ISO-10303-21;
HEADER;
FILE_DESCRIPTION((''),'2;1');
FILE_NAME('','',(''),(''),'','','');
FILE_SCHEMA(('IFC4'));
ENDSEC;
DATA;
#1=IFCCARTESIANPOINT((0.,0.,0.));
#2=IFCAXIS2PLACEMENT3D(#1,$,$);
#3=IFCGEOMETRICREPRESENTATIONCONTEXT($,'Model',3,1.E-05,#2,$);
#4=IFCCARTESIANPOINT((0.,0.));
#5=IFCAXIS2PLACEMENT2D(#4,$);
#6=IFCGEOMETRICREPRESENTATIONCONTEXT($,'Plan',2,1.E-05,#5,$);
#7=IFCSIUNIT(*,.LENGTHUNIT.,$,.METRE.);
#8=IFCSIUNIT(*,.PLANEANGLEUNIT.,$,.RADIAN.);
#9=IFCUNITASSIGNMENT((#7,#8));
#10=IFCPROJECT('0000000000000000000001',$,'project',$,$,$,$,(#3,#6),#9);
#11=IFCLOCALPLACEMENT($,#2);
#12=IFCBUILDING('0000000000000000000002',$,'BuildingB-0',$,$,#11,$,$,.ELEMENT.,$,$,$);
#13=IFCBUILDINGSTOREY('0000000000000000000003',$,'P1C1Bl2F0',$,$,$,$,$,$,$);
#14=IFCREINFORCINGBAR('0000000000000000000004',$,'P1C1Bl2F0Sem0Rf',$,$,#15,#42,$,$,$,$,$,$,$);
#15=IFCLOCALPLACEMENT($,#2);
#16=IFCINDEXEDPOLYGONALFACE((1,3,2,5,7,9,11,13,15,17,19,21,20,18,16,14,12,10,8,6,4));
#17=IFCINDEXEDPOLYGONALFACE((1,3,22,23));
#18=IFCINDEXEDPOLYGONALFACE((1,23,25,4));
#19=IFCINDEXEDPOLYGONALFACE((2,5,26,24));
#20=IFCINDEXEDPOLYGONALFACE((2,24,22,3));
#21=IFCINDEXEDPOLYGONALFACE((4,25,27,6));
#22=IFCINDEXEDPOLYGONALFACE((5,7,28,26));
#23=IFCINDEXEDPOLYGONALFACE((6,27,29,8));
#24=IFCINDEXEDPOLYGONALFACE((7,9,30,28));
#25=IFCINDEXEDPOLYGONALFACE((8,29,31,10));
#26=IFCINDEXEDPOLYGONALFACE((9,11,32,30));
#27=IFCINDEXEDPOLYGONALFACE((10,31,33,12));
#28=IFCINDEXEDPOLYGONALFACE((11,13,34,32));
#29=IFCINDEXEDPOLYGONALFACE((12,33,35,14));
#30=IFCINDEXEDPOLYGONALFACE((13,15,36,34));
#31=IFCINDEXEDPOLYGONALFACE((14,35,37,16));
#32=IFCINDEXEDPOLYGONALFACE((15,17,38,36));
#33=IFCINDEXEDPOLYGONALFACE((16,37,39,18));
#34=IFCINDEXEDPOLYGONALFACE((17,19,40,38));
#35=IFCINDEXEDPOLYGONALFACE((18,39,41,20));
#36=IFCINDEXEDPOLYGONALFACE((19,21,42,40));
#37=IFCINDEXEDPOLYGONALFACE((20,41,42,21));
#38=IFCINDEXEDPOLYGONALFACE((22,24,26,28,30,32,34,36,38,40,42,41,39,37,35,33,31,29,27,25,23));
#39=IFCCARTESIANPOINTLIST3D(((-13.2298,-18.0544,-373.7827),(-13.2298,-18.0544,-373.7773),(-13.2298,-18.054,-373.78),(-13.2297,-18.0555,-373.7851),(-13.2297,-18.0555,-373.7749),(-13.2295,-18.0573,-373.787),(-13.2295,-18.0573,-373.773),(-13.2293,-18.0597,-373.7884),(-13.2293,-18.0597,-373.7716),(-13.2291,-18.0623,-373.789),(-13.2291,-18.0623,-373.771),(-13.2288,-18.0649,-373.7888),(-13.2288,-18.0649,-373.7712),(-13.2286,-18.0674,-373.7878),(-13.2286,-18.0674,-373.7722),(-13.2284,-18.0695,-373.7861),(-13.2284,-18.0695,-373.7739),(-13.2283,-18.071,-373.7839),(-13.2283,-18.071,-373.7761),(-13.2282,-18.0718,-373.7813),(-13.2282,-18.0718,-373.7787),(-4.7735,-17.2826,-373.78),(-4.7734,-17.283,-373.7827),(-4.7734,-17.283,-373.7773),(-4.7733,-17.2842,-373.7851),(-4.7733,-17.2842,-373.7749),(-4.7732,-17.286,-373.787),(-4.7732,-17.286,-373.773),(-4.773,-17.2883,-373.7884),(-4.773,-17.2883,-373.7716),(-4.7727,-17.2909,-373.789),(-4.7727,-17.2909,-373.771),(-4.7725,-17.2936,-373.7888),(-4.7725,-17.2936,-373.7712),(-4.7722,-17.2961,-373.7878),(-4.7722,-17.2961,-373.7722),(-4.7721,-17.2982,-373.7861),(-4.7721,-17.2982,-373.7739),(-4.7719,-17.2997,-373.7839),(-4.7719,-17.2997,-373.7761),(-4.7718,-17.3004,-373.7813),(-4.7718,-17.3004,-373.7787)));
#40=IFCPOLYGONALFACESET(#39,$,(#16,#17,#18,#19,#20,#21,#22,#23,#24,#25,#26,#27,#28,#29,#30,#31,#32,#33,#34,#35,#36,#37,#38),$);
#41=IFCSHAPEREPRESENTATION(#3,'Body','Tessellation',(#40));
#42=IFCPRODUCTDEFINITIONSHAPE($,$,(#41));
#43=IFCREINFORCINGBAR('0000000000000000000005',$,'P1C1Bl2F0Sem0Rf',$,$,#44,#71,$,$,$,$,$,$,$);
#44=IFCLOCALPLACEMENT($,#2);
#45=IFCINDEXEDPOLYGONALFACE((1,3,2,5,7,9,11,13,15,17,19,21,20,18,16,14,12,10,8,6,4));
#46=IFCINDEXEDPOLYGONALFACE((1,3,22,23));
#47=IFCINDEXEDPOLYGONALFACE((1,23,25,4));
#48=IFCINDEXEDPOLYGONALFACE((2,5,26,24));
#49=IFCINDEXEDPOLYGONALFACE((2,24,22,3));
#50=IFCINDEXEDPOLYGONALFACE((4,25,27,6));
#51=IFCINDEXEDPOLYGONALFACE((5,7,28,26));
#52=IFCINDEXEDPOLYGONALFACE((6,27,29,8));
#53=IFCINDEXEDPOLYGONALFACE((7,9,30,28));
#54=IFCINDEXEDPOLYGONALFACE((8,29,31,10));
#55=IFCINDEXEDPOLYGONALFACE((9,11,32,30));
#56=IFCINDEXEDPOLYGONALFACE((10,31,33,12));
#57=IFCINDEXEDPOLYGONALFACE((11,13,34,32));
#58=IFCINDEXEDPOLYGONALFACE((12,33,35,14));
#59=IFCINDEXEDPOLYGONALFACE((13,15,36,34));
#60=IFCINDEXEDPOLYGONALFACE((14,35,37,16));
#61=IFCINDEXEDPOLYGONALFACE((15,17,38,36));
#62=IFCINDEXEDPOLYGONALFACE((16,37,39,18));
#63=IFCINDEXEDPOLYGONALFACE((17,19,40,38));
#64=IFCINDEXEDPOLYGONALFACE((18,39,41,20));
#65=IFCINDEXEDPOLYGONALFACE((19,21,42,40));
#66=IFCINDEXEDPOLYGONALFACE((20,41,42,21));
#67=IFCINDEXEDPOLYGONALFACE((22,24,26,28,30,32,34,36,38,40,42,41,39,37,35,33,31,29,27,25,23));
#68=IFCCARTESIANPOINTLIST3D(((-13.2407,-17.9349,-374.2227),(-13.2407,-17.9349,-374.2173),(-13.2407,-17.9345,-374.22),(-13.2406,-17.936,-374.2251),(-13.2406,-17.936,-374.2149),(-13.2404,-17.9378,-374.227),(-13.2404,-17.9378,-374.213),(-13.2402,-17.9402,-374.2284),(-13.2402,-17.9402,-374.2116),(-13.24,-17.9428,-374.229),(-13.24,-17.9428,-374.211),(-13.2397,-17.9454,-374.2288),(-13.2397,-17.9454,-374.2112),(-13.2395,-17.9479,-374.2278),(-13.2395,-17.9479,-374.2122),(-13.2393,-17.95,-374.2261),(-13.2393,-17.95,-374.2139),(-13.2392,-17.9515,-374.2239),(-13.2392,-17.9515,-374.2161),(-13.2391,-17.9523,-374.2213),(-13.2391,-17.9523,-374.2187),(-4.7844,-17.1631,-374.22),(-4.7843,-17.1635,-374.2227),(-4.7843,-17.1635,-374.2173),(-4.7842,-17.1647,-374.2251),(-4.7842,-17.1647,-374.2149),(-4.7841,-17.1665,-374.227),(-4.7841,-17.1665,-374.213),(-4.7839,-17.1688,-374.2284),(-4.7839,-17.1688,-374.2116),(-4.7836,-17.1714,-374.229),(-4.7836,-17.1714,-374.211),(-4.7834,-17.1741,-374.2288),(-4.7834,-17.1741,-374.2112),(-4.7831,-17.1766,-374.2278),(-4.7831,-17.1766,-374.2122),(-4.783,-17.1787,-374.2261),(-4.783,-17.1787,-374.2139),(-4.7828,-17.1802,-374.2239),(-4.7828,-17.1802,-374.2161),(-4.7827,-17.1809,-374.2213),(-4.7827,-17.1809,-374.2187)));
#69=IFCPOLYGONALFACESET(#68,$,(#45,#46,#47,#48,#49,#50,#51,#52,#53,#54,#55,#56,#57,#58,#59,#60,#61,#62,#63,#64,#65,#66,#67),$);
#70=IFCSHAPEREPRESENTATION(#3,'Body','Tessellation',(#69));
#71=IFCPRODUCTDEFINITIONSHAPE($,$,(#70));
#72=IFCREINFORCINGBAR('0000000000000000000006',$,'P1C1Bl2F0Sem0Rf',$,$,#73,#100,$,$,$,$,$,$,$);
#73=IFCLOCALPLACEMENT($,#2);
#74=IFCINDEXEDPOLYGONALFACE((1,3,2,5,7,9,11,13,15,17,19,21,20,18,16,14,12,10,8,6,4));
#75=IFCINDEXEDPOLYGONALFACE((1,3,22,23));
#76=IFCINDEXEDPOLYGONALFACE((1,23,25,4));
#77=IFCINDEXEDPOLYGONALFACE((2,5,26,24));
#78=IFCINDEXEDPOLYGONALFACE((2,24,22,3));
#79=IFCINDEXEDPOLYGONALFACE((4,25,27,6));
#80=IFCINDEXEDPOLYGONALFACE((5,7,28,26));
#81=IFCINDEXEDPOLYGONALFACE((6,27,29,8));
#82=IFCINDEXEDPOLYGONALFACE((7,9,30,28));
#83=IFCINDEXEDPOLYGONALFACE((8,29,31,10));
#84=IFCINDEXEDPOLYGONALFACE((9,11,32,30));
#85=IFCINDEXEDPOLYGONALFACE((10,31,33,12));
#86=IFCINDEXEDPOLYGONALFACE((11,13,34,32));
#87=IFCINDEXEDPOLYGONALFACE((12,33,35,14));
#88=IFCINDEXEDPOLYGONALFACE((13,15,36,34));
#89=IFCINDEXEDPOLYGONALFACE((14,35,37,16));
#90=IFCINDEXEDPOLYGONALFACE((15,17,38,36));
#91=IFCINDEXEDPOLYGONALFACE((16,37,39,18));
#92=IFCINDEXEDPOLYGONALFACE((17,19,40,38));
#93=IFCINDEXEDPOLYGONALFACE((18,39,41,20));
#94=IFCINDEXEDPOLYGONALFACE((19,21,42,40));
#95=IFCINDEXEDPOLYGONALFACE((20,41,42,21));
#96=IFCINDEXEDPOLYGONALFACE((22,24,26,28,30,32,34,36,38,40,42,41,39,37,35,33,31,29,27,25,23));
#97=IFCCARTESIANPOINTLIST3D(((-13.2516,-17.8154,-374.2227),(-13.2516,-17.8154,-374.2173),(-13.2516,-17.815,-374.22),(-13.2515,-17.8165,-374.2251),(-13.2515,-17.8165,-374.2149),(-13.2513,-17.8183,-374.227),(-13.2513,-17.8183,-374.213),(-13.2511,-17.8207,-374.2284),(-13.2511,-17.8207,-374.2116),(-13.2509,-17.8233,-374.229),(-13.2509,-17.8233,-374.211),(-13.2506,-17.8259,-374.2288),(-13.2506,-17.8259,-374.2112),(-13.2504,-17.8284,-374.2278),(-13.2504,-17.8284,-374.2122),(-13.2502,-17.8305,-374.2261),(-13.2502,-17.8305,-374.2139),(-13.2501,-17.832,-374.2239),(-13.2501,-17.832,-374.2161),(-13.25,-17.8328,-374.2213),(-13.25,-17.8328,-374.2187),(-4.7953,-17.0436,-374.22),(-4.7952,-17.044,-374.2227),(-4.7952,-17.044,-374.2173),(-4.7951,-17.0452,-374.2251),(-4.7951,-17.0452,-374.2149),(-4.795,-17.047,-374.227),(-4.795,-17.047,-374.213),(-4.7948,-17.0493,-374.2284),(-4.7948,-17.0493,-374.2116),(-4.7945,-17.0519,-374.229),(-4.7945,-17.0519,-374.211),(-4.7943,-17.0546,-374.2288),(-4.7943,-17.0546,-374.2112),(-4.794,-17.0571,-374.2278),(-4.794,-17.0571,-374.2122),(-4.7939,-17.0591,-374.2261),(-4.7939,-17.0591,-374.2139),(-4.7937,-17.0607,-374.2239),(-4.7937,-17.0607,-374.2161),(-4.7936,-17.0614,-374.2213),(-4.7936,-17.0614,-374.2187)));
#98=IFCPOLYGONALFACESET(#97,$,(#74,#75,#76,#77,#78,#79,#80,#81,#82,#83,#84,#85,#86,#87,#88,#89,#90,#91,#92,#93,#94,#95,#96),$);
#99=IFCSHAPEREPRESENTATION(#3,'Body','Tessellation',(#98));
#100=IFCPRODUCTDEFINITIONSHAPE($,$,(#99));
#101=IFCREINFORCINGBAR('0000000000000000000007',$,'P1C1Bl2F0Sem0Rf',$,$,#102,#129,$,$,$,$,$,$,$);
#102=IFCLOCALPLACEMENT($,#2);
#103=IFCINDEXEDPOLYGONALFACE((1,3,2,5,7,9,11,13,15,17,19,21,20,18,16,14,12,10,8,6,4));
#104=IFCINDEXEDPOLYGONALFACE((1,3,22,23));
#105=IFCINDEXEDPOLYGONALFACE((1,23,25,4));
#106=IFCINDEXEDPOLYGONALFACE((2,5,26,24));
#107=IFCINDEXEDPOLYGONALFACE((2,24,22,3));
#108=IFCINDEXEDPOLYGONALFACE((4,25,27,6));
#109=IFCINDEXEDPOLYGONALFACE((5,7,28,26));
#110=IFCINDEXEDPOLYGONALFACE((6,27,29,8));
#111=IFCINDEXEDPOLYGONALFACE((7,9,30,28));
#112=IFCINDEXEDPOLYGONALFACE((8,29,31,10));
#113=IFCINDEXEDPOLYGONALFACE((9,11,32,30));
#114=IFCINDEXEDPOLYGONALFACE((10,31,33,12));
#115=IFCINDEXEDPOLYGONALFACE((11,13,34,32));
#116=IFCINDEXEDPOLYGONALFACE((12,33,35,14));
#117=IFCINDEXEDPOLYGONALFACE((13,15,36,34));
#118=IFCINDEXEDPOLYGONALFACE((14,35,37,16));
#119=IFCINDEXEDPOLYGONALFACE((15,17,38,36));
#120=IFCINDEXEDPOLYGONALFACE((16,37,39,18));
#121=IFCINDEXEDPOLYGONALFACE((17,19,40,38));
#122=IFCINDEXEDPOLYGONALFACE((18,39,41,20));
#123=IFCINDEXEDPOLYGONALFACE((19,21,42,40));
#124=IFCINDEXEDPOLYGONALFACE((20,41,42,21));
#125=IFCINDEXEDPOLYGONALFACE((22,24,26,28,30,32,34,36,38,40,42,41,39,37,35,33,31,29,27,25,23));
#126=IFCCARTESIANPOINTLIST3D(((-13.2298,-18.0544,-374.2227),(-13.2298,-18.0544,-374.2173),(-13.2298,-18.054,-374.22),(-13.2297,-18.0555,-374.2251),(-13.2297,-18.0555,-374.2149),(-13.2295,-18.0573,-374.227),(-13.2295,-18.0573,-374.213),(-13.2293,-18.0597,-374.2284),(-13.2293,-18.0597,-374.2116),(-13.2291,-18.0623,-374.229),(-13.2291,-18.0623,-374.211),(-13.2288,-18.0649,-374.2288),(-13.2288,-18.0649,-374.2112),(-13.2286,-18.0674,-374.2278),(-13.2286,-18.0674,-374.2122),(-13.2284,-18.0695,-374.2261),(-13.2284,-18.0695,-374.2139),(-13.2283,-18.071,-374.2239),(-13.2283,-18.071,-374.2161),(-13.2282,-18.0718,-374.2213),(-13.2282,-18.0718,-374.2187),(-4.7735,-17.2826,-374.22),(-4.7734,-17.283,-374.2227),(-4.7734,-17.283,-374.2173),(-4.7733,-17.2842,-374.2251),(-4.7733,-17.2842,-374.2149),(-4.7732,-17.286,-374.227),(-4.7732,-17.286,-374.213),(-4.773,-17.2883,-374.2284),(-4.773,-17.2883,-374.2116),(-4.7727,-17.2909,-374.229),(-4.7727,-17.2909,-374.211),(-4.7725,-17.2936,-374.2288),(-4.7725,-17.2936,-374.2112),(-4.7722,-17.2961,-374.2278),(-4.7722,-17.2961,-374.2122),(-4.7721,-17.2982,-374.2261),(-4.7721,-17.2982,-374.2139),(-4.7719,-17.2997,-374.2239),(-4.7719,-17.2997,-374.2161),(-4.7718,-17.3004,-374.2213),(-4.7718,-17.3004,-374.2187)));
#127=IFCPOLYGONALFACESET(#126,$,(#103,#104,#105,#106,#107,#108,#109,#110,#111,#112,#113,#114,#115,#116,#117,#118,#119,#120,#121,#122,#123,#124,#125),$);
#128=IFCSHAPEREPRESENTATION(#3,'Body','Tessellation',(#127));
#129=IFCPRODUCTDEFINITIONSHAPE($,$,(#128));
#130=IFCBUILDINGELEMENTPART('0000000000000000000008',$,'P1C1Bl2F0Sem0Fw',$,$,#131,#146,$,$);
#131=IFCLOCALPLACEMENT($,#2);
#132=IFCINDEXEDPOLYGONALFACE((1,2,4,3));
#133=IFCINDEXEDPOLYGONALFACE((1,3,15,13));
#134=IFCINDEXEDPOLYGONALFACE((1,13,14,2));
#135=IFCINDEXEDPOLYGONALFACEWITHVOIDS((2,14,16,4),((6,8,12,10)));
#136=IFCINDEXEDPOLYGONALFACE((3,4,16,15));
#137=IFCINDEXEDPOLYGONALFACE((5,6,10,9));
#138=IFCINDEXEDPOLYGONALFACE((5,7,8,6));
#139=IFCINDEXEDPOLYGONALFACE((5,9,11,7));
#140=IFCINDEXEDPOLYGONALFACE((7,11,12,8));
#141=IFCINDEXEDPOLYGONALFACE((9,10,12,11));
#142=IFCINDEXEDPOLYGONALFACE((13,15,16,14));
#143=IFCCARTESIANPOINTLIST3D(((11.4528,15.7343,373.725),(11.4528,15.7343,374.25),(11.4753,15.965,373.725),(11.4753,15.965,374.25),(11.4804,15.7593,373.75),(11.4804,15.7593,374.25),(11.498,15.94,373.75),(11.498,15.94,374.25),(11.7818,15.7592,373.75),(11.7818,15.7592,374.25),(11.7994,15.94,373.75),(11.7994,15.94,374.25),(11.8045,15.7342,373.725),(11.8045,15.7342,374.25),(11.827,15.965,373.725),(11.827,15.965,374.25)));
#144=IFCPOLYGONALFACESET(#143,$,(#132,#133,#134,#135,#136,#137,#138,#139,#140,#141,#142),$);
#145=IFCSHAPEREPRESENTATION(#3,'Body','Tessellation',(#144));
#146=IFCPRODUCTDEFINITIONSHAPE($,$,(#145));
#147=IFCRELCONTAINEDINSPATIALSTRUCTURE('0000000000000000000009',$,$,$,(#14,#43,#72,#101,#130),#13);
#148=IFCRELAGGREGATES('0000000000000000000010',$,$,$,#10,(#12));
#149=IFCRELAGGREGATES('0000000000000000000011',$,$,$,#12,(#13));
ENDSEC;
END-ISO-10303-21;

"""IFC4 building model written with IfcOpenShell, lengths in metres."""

from ifc_helpers import new_model, entity, si_unit, origin, origin_2d, place, context, project, spatial, polyline, outline, extrude, element, save


model = new_model("IFC4")

# Units and contexts
model_context = context("Model", 3, precision=1e-05, world=origin())
plan_context = context("Plan", 2, precision=1e-05, world=origin_2d())
ifc_project = project(units=[si_unit("LENGTHUNIT", "METRE"), si_unit("PLANEANGLEUNIT", "RADIAN")], contexts=[model_context, plan_context])

# Building, storey
building_placement = place(None, origin())
building = spatial("IfcBuilding", under=ifc_project, at=building_placement, Name="BuildingB-0", CompositionType="ELEMENT")
storey = spatial("IfcBuildingStorey", under=building, Name="P1C1Bl2F0")

# Reinforcing bars
element("IfcReinforcingBar", 1, inside=storey, Name="P1C1Bl2F0Sem0Rf", context=model_context, shape_type="SweptSolid", body=[
    entity("IfcSurfaceCurveSweptAreaSolid", entity("IfcCircleProfileDef", "AREA", None, None, 0.009), None, entity("IfcPolyline", [entity("IfcCartesianPoint", [4.7727, 17.2916, 373.78]), entity("IfcCartesianPoint", [13.229, 18.0629, 373.78])]), None, None, entity("IfcPlane", entity("IfcAxis2Placement3D", entity("IfcCartesianPoint", [4.7727, 17.2916, 373.78]), entity("IfcDirection", [0.0, 0.0, 1.0]), entity("IfcDirection", [1.0, 0.0, 0.0])))),
])
element("IfcReinforcingBar", 2, inside=storey, Name="P1C1Bl2F0Sem0Rf", context=model_context, shape_type="SweptSolid", body=[
    entity("IfcSurfaceCurveSweptAreaSolid", entity("IfcCircleProfileDef", "AREA", None, None, 0.009), None, entity("IfcPolyline", [entity("IfcCartesianPoint", [4.7836, 17.1721, 374.22]), entity("IfcCartesianPoint", [13.2399, 17.9434, 374.22])]), None, None, entity("IfcPlane", entity("IfcAxis2Placement3D", entity("IfcCartesianPoint", [4.7836, 17.1721, 374.22]), entity("IfcDirection", [0.0, 0.0, 1.0]), entity("IfcDirection", [1.0, 0.0, 0.0])))),
])
element("IfcReinforcingBar", 3, inside=storey, Name="P1C1Bl2F0Sem0Rf", context=model_context, shape_type="SweptSolid", body=[
    entity("IfcSurfaceCurveSweptAreaSolid", entity("IfcCircleProfileDef", "AREA", None, None, 0.009), None, entity("IfcPolyline", [entity("IfcCartesianPoint", [4.7945, 17.0526, 374.22]), entity("IfcCartesianPoint", [13.2508, 17.8239, 374.22])]), None, None, entity("IfcPlane", entity("IfcAxis2Placement3D", entity("IfcCartesianPoint", [4.7945, 17.0526, 374.22]), entity("IfcDirection", [0.0, 0.0, 1.0]), entity("IfcDirection", [1.0, 0.0, 0.0])))),
])
element("IfcReinforcingBar", 4, inside=storey, Name="P1C1Bl2F0Sem0Rf", context=model_context, shape_type="SweptSolid", body=[
    entity("IfcSurfaceCurveSweptAreaSolid", entity("IfcCircleProfileDef", "AREA", None, None, 0.009), None, entity("IfcPolyline", [entity("IfcCartesianPoint", [4.7727, 17.2916, 374.22]), entity("IfcCartesianPoint", [13.229, 18.0629, 374.22])]), None, None, entity("IfcPlane", entity("IfcAxis2Placement3D", entity("IfcCartesianPoint", [4.7727, 17.2916, 374.22]), entity("IfcDirection", [0.0, 0.0, 1.0]), entity("IfcDirection", [1.0, 0.0, 0.0])))),
])

# Building element part, opening
building_element_part_1 = element("IfcBuildingElementPart", 5, inside=storey, Name="P1C1Bl2F0Sem0Fw", context=model_context, shape_type="SweptSolid", body=[
    extrude(outline(polyline([(11.4528, 15.7343, 373.725), (11.4753, 15.965, 373.725), (11.827, 15.965, 373.725), (11.8045, 15.7342, 373.725), (11.4528, 15.7343, 373.725)])), None, (0.0, 0.0, 1.0), 0.525),
])
element("IfcOpeningElement", 6, inside=storey, cuts=building_element_part_1, context=model_context, shape_type="SweptSolid", body=[
    extrude(outline(polyline([(11.4804, 15.7593, 373.75), (11.498, 15.94, 373.75), (11.7994, 15.94, 373.75), (11.7818, 15.7592, 373.75), (11.4804, 15.7593, 373.75)])), None, (0.0, 0.0, 1.0), 0.5),
])

save(model, "model.ifc")
